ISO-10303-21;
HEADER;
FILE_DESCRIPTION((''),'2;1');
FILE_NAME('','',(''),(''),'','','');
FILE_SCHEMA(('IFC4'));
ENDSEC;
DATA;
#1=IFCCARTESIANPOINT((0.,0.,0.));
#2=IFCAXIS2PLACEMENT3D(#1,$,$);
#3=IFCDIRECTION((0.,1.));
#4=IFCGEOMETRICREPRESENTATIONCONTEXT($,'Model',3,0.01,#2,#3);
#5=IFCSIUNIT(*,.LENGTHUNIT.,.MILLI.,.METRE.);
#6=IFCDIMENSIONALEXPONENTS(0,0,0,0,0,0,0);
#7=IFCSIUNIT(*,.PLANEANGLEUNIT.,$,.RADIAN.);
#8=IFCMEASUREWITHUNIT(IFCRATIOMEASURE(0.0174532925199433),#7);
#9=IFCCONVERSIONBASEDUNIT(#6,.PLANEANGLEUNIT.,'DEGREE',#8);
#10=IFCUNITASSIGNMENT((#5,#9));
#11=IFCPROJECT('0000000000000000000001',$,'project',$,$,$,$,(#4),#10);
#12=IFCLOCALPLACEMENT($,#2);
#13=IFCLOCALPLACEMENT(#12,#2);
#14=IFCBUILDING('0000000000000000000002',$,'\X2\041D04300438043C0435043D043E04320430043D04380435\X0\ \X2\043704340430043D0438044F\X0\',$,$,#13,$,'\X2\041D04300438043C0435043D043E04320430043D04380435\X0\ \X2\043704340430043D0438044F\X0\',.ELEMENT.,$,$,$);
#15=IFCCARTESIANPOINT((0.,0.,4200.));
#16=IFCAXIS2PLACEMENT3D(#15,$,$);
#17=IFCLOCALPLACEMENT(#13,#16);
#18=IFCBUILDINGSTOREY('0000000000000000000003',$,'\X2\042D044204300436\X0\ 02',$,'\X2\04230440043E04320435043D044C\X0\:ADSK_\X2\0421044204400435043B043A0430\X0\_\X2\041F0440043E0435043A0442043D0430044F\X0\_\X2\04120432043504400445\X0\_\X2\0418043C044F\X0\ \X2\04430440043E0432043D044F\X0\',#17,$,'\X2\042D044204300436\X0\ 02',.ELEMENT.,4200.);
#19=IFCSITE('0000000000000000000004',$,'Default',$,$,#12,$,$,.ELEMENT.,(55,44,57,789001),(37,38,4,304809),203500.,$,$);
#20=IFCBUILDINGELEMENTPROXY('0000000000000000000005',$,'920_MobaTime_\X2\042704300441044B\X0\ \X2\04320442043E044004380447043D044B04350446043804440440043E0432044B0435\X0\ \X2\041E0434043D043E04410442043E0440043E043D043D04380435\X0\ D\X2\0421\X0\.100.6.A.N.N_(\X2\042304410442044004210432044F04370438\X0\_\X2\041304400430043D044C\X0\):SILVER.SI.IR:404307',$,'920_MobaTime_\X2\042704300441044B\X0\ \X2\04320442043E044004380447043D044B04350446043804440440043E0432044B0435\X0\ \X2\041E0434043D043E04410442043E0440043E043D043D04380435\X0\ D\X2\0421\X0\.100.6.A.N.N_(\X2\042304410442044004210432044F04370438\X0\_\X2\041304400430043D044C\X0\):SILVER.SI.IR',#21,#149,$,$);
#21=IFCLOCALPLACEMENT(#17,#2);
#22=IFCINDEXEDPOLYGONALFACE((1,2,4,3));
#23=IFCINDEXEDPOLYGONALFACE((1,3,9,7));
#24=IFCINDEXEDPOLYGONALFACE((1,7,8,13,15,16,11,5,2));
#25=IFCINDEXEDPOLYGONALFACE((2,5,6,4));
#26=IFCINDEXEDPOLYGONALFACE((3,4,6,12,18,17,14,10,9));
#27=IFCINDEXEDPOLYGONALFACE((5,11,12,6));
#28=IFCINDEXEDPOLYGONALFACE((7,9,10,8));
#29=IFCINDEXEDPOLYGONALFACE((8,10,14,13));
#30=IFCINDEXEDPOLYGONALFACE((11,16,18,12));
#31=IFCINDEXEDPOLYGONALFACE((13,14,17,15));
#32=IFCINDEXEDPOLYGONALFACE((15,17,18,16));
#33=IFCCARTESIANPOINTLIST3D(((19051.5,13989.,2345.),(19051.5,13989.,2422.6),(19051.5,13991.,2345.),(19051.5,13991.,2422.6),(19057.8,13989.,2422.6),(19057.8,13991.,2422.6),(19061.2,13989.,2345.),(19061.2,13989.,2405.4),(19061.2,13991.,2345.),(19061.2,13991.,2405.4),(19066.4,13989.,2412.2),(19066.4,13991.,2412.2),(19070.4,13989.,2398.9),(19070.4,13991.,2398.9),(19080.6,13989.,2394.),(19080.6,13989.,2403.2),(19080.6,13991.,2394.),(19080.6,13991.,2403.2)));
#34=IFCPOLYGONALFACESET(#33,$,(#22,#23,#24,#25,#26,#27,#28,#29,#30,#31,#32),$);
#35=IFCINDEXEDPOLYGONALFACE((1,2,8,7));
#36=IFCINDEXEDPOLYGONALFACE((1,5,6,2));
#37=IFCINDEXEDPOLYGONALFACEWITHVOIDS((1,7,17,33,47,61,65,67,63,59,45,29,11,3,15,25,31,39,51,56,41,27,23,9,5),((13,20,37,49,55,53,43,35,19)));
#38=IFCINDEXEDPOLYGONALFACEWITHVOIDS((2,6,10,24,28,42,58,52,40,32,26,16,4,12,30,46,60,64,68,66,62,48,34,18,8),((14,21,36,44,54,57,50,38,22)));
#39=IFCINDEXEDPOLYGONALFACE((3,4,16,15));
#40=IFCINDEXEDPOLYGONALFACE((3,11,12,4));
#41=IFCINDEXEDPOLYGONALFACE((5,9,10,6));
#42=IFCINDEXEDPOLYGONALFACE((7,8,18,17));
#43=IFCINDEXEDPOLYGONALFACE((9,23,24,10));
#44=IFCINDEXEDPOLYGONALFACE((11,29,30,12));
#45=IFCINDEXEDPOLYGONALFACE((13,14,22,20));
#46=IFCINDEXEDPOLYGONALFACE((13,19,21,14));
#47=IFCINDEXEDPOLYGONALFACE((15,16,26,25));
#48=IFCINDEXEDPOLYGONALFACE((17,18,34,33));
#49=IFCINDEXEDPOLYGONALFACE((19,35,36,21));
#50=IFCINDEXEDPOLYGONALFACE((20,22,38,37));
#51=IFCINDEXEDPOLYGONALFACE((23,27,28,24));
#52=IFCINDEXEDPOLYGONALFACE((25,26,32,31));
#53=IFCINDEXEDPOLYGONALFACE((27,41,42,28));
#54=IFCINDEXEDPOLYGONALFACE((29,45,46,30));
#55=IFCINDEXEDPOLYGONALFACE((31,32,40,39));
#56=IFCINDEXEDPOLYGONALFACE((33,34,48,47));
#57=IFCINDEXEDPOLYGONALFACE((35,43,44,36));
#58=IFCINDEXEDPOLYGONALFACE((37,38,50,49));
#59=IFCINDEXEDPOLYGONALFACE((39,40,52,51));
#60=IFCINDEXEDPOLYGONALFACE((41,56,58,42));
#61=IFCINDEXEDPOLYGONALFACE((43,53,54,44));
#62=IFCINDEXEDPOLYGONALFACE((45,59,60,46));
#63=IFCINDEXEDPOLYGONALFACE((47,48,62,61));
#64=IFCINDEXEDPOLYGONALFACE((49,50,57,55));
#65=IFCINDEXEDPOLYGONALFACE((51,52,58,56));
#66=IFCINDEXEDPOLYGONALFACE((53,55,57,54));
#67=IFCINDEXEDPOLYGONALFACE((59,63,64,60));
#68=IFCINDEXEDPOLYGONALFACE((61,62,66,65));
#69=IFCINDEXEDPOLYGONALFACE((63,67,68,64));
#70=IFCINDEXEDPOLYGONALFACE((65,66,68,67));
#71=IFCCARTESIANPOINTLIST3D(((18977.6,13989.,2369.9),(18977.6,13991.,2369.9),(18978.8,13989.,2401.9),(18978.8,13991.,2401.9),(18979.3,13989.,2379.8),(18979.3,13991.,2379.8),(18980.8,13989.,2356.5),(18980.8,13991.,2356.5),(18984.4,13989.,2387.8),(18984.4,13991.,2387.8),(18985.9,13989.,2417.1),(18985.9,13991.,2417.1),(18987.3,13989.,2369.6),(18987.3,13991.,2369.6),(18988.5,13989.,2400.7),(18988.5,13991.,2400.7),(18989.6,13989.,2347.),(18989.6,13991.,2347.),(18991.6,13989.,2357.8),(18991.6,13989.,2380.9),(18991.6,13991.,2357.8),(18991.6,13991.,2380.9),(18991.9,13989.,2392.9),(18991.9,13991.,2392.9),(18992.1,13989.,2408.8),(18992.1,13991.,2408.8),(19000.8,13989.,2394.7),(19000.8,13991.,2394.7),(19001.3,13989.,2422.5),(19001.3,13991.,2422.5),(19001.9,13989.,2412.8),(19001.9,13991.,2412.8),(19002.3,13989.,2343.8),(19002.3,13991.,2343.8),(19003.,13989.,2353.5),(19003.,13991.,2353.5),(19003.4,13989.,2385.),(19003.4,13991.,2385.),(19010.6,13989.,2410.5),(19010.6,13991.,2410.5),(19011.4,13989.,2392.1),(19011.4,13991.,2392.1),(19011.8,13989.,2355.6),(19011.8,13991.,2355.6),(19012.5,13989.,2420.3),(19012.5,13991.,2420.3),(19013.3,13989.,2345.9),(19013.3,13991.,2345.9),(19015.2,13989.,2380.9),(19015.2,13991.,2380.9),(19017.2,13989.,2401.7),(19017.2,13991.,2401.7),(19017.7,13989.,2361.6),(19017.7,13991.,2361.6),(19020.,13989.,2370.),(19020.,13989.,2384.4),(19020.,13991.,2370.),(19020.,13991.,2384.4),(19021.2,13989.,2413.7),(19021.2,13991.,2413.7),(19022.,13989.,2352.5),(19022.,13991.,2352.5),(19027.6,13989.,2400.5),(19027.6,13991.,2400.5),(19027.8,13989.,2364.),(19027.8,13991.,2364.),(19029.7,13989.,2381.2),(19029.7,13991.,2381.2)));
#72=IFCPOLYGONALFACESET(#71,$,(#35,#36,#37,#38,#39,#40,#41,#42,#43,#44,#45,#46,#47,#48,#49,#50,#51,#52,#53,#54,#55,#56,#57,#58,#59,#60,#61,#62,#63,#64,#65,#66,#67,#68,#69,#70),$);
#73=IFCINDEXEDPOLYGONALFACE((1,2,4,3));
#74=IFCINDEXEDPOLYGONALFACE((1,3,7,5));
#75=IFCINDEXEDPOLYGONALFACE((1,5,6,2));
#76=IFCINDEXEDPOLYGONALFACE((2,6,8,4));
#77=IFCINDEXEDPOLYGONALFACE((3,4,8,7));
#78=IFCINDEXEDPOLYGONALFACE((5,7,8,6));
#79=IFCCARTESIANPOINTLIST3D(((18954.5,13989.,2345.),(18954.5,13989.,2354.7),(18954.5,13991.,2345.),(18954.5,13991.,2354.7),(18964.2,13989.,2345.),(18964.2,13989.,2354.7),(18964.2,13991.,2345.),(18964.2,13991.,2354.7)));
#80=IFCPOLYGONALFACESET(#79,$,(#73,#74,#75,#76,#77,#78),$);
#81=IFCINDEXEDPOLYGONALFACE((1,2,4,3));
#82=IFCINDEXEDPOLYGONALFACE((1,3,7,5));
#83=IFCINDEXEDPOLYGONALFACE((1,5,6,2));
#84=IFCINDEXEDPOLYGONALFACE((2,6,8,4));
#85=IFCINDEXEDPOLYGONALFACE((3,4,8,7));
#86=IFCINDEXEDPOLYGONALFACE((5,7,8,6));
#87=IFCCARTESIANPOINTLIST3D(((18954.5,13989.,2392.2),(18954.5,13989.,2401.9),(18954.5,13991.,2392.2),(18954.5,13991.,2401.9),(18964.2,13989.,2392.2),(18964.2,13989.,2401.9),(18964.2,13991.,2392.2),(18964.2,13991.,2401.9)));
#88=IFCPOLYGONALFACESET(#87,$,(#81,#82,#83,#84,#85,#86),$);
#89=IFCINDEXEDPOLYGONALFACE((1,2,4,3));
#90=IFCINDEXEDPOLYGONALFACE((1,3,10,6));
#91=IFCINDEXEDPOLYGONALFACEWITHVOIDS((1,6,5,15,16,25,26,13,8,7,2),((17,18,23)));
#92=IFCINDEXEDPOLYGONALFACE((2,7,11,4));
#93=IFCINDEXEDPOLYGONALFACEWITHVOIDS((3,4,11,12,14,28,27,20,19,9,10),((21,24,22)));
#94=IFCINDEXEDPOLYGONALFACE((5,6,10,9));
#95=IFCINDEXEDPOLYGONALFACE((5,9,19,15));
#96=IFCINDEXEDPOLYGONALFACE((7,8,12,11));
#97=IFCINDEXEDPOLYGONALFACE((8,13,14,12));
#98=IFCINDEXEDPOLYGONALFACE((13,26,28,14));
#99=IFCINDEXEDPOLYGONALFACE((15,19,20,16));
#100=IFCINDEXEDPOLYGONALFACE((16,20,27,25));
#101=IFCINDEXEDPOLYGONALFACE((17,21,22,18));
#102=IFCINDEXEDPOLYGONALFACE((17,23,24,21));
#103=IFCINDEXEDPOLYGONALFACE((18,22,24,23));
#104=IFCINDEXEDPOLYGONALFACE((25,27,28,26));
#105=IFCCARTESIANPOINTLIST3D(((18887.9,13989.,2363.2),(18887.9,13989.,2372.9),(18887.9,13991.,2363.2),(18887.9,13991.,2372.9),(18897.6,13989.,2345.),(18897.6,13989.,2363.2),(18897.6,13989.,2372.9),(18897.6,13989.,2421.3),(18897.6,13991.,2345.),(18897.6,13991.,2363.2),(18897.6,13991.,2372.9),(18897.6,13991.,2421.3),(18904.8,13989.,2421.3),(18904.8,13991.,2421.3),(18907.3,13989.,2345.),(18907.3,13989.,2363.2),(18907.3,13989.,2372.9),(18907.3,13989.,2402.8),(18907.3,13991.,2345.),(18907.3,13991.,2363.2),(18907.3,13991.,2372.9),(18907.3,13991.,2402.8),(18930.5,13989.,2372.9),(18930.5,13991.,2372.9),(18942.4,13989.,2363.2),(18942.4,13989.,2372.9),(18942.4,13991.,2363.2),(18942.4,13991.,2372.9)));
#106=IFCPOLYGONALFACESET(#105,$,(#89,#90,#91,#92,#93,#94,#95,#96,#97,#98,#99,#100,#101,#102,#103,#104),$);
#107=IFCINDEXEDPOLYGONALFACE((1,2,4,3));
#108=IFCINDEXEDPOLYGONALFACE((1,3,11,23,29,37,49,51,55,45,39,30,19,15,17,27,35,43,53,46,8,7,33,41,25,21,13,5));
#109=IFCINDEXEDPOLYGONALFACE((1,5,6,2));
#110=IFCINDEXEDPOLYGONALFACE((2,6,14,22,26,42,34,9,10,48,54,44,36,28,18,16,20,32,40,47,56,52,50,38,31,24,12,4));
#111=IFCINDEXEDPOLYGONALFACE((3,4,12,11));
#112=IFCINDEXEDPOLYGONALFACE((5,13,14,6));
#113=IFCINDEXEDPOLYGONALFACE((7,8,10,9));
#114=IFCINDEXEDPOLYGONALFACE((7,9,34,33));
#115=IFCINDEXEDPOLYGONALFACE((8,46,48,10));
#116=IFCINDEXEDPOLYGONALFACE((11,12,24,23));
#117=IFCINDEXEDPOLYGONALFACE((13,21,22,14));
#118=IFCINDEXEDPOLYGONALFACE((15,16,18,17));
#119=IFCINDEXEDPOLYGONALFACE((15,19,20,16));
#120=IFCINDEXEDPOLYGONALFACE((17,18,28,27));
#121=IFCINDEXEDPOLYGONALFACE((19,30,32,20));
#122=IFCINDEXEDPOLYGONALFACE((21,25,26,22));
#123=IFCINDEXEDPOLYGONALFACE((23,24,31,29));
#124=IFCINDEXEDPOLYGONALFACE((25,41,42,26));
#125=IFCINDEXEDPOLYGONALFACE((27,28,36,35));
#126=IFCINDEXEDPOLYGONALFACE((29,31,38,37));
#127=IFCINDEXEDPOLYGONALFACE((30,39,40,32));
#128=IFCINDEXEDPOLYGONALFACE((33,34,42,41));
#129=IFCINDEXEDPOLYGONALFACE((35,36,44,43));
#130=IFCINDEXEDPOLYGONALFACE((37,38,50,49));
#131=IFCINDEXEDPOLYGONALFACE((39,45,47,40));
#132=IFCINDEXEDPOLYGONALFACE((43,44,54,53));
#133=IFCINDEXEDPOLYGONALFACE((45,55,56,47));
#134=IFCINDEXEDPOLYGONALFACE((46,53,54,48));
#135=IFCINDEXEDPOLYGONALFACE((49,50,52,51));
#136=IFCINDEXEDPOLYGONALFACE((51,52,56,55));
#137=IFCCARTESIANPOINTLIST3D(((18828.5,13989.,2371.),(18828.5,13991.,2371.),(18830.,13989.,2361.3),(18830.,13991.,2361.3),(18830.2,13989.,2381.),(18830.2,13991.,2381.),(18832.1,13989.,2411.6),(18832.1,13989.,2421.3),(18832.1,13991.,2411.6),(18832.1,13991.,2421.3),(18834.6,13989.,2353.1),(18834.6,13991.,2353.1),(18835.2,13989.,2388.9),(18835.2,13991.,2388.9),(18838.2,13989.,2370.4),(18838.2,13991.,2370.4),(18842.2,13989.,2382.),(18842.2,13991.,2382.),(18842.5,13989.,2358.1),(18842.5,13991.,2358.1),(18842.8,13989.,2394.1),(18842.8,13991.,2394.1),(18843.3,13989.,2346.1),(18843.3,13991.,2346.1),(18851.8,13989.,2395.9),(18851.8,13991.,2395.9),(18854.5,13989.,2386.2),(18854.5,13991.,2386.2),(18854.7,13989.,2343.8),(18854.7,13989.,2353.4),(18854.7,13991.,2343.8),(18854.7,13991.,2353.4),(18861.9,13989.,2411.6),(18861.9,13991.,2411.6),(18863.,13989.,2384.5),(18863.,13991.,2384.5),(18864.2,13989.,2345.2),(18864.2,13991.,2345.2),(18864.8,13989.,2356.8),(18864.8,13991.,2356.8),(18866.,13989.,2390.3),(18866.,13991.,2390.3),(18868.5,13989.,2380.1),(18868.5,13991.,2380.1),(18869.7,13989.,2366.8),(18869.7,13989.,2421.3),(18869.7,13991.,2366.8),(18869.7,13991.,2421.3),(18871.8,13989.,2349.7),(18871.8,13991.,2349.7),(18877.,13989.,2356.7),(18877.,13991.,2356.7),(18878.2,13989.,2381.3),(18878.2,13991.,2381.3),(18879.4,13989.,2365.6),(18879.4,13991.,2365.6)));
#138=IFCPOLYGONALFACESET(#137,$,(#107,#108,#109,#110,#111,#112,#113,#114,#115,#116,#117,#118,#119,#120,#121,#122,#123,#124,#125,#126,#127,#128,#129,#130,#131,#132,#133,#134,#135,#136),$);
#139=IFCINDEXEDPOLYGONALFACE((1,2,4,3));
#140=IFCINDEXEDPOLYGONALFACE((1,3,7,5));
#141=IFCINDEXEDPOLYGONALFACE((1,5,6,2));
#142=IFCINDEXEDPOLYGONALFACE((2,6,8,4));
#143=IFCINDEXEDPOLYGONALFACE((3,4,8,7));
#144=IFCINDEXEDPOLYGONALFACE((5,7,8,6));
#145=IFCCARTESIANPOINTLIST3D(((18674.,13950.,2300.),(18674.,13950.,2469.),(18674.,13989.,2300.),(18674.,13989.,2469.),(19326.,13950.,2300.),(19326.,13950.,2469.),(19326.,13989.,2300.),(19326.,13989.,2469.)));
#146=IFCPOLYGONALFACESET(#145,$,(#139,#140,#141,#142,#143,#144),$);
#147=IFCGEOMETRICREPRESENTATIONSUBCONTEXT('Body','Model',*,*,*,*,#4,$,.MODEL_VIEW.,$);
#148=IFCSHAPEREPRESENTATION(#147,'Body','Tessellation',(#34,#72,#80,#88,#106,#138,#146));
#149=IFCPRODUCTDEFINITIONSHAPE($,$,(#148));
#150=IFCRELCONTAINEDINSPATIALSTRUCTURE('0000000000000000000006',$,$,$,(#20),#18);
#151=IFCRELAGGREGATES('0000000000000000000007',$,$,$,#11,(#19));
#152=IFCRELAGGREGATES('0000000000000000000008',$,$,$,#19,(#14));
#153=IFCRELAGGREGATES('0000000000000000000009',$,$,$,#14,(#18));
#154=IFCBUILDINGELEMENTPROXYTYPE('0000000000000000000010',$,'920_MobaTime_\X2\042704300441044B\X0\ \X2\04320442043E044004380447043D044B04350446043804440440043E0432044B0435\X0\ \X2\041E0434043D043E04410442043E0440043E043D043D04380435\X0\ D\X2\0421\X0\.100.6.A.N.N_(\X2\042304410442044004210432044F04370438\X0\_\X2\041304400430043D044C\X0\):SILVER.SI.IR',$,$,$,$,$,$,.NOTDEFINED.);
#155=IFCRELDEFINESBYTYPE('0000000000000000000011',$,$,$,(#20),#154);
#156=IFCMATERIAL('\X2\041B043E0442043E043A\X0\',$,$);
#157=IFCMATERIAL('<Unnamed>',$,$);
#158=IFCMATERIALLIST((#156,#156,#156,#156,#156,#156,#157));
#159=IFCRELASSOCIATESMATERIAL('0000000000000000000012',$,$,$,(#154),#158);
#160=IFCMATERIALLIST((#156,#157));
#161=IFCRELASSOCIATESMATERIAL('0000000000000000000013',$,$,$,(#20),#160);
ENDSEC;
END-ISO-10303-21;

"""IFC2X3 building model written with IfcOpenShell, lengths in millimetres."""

from ifc_helpers import new_model, entity, si_unit, converted_unit, direction, frame, origin, origin_2d_with_axis, place, context, subcontext, project, spatial, polyline, rectangle, outline, extrude, source, transform, mapped, material, material_list, type_object, type_shapes, element, save


model = new_model("IFC2X3")

# Units and contexts
model_context = context("Model", 3, precision=0.01, world=origin(), true_north=direction((0.0, 1.0)))
body_context = subcontext(model_context, "Body", "Model", "MODEL_VIEW")
ifc_project = project(units=[si_unit("LENGTHUNIT", "METRE", prefix="MILLI"), converted_unit("PLANEANGLEUNIT", "DEGREE", entity("IfcRatioMeasure", 0.0174532925199433), si_unit("PLANEANGLEUNIT", "RADIAN"), dimensions=[0, 0, 0, 0, 0, 0, 0])], contexts=[model_context])

# Site, building, storey
site_placement = place(None, origin())
site = spatial("IfcSite", under=ifc_project, at=site_placement, Name="Default", CompositionType="ELEMENT", RefLatitude=(55, 44, 57, 789001), RefLongitude=(37, 38, 4, 304809), RefElevation=203500.0)
building_placement = place(site_placement, origin())
building = spatial("IfcBuilding", under=site, at=building_placement, Name="Наименование здания", LongName="Наименование здания", CompositionType="ELEMENT")
storey_placement = place(building_placement, frame((0.0, 0.0, 4200.0)))
storey = spatial("IfcBuildingStorey", under=building, at=storey_placement, Name="Этаж 02", ObjectType="Уровень:ADSK_Стрелка_Проектная_Вверх_Имя уровня", LongName="Этаж 02", CompositionType="ELEMENT", Elevation=4200.0)

# Building element proxy
ifc_material_1 = material(Name="Лоток")
ifc_material_2 = material(Name="<Unnamed>")
ifc_material_list_1 = material_list([ifc_material_1, ifc_material_2])
ifc_material_list_2 = material_list([ifc_material_1, ifc_material_1, ifc_material_1, ifc_material_1, ifc_material_1, ifc_material_1, ifc_material_2])
building_element_proxy_type_1 = type_object("IfcBuildingElementProxyType", Name="920_MobaTime_Часы вторичныецифровые Односторонние DС.100.6.A.N.N_(УстрСвязи_Грань):SILVER.SI.IR", PredefinedType="NOTDEFINED", material=ifc_material_list_2)
shared_shape_1 = source(origin(), body_context, "Body", "SweptSolid", [
    extrude(outline(polyline([(-49.3, -13.1), (28.2, -13.1), (28.2, -6.8), (17.9, 1.8), (8.8, 16.0), (-0.3, 16.0), (4.6, 5.8), (11.1, -3.4), (-49.3, -3.4), (-49.3, -13.1)])), frame((-64.6, 9.8, 39.0), z_axis=(0.0, 0.0, 1.0), x_axis=(0.0, 1.0, 0.0)), (0.0, 0.0, 1.0), 2.0),
    extrude(outline(polyline([(2.2, -27.6), (19.0, -27.6), (30.5, -16.1), (33.3, -4.9), (31.0, 5.8), (21.8, 17.2), (5.2, 27.3), (-11.1, 33.0), (-24.0, 32.7), (-33.6, 27.6), (-40.3, 18.6), (-42.8, 5.7), (-38.0, -6.3), (-27.2, -14.9), (-17.5, -17.7), (-8.2, -16.4), (-0.3, -11.9), (5.1, -4.5), (7.3, 6.2), (4.0, 17.2), (18.4, 7.3), (23.6, -2.4), (22.0, -11.4), (14.2, -18.4), (5.3, -18.3), (2.2, -27.6)]), holes=[polyline([(-9.0, 23.3), (-1.3, 14.3), (-2.5, 2.0), (-11.4, -7.0), (-23.4, -6.0), (-32.2, 2.9), (-31.2, 15.1), (-25.6, 22.1), (-17.5, 24.9), (-9.0, 23.3)])]), frame((-2.7, 3.6, 39.0), z_axis=(0.0, 0.0, 1.0), x_axis=(-0.427649, 0.903945, 0.0)), (0.0, 0.0, 1.0), 2.0),
    extrude(rectangle(XDim=9.7, YDim=9.7, at=origin_2d_with_axis()), frame((40.6, -34.7, 39.0)), (0.0, 0.0, 1.0), 2.0),
    extrude(rectangle(XDim=9.7, YDim=9.7, at=origin_2d_with_axis()), frame((40.6, 12.6, 39.0)), (0.0, 0.0, 1.0), 2.0),
    extrude(outline(polyline([(-0.9, -28.1), (8.8, -28.1), (8.8, -9.9), (18.5, -9.9), (18.5, -0.2), (8.8, -0.2), (8.8, 48.3), (1.5, 48.3), (-36.0, -0.2), (-36.0, -9.9), (-0.9, -9.9), (-0.9, -28.1)]), holes=[polyline([(-0.9, -0.2), (-24.1, -0.2), (-0.9, 29.7), (-0.9, -0.2)])]), frame((93.6, -11.4, 39.0)), (0.0, 0.0, 1.0), 2.0),
    extrude(outline(polyline([(3.3, -28.3), (12.5, -28.3), (20.5, -25.0), (26.8, -18.9), (30.7, -10.0), (31.4, 1.6), (26.9, 11.8), (20.1, 18.4), (11.1, 22.3), (1.0, 23.3), (-7.9, 20.4), (-14.9, 14.5), (-18.9, 6.2), (-17.1, -9.0), (-36.7, 0.5), (-29.1, 29.2), (-38.5, 31.7), (-48.1, -4.6), (-11.6, -23.1), (-8.0, -14.0), (-10.8, -7.6), (-10.2, 1.1), (-3.0, 11.8), (9.2, 12.8), (20.0, 5.5), (21.4, -7.5), (15.5, -16.4), (4.6, -18.6), (3.3, -28.3)])), frame((147.1, -8.5, 39.0), z_axis=(0.0, 0.0, 1.0), x_axis=(0.256974, -0.966418, 0.0)), (0.0, 0.0, 1.0), 2.0),
    extrude(rectangle(XDim=652.0, YDim=169.0, at=origin_2d_with_axis()), frame((0.0, 0.0, 0.0), z_axis=(0.0, 0.0, 1.0), x_axis=(-1.0, 0.0, 0.0)), (0.0, 0.0, 1.0), 39.0),
])
type_shapes(building_element_proxy_type_1, [shared_shape_1])
for number, where, z_axis, x_axis, name in (
    (1, (19000.0, 13950.0, 2384.5), (0.0, 1.0, 0.0), (-1.0, 0.0, 0.0), "920_MobaTime_Часы вторичныецифровые Односторонние DС.100.6.A.N.N_(УстрСвязи_Грань):SILVER.SI.IR:404307"),
):
    element("IfcBuildingElementProxy", number, at=place(storey_placement, frame(where, z_axis=z_axis, x_axis=x_axis)), inside=storey, type_object=building_element_proxy_type_1, material=ifc_material_list_1, Name=name, ObjectType="920_MobaTime_Часы вторичныецифровые Односторонние DС.100.6.A.N.N_(УстрСвязи_Грань):SILVER.SI.IR", context=body_context, shape_type="MappedRepresentation", body=[
        mapped(shared_shape_1, transform((0.0, 0.0, 0.0), scale=1.0)),
    ])

save(model, "model.ifc")
